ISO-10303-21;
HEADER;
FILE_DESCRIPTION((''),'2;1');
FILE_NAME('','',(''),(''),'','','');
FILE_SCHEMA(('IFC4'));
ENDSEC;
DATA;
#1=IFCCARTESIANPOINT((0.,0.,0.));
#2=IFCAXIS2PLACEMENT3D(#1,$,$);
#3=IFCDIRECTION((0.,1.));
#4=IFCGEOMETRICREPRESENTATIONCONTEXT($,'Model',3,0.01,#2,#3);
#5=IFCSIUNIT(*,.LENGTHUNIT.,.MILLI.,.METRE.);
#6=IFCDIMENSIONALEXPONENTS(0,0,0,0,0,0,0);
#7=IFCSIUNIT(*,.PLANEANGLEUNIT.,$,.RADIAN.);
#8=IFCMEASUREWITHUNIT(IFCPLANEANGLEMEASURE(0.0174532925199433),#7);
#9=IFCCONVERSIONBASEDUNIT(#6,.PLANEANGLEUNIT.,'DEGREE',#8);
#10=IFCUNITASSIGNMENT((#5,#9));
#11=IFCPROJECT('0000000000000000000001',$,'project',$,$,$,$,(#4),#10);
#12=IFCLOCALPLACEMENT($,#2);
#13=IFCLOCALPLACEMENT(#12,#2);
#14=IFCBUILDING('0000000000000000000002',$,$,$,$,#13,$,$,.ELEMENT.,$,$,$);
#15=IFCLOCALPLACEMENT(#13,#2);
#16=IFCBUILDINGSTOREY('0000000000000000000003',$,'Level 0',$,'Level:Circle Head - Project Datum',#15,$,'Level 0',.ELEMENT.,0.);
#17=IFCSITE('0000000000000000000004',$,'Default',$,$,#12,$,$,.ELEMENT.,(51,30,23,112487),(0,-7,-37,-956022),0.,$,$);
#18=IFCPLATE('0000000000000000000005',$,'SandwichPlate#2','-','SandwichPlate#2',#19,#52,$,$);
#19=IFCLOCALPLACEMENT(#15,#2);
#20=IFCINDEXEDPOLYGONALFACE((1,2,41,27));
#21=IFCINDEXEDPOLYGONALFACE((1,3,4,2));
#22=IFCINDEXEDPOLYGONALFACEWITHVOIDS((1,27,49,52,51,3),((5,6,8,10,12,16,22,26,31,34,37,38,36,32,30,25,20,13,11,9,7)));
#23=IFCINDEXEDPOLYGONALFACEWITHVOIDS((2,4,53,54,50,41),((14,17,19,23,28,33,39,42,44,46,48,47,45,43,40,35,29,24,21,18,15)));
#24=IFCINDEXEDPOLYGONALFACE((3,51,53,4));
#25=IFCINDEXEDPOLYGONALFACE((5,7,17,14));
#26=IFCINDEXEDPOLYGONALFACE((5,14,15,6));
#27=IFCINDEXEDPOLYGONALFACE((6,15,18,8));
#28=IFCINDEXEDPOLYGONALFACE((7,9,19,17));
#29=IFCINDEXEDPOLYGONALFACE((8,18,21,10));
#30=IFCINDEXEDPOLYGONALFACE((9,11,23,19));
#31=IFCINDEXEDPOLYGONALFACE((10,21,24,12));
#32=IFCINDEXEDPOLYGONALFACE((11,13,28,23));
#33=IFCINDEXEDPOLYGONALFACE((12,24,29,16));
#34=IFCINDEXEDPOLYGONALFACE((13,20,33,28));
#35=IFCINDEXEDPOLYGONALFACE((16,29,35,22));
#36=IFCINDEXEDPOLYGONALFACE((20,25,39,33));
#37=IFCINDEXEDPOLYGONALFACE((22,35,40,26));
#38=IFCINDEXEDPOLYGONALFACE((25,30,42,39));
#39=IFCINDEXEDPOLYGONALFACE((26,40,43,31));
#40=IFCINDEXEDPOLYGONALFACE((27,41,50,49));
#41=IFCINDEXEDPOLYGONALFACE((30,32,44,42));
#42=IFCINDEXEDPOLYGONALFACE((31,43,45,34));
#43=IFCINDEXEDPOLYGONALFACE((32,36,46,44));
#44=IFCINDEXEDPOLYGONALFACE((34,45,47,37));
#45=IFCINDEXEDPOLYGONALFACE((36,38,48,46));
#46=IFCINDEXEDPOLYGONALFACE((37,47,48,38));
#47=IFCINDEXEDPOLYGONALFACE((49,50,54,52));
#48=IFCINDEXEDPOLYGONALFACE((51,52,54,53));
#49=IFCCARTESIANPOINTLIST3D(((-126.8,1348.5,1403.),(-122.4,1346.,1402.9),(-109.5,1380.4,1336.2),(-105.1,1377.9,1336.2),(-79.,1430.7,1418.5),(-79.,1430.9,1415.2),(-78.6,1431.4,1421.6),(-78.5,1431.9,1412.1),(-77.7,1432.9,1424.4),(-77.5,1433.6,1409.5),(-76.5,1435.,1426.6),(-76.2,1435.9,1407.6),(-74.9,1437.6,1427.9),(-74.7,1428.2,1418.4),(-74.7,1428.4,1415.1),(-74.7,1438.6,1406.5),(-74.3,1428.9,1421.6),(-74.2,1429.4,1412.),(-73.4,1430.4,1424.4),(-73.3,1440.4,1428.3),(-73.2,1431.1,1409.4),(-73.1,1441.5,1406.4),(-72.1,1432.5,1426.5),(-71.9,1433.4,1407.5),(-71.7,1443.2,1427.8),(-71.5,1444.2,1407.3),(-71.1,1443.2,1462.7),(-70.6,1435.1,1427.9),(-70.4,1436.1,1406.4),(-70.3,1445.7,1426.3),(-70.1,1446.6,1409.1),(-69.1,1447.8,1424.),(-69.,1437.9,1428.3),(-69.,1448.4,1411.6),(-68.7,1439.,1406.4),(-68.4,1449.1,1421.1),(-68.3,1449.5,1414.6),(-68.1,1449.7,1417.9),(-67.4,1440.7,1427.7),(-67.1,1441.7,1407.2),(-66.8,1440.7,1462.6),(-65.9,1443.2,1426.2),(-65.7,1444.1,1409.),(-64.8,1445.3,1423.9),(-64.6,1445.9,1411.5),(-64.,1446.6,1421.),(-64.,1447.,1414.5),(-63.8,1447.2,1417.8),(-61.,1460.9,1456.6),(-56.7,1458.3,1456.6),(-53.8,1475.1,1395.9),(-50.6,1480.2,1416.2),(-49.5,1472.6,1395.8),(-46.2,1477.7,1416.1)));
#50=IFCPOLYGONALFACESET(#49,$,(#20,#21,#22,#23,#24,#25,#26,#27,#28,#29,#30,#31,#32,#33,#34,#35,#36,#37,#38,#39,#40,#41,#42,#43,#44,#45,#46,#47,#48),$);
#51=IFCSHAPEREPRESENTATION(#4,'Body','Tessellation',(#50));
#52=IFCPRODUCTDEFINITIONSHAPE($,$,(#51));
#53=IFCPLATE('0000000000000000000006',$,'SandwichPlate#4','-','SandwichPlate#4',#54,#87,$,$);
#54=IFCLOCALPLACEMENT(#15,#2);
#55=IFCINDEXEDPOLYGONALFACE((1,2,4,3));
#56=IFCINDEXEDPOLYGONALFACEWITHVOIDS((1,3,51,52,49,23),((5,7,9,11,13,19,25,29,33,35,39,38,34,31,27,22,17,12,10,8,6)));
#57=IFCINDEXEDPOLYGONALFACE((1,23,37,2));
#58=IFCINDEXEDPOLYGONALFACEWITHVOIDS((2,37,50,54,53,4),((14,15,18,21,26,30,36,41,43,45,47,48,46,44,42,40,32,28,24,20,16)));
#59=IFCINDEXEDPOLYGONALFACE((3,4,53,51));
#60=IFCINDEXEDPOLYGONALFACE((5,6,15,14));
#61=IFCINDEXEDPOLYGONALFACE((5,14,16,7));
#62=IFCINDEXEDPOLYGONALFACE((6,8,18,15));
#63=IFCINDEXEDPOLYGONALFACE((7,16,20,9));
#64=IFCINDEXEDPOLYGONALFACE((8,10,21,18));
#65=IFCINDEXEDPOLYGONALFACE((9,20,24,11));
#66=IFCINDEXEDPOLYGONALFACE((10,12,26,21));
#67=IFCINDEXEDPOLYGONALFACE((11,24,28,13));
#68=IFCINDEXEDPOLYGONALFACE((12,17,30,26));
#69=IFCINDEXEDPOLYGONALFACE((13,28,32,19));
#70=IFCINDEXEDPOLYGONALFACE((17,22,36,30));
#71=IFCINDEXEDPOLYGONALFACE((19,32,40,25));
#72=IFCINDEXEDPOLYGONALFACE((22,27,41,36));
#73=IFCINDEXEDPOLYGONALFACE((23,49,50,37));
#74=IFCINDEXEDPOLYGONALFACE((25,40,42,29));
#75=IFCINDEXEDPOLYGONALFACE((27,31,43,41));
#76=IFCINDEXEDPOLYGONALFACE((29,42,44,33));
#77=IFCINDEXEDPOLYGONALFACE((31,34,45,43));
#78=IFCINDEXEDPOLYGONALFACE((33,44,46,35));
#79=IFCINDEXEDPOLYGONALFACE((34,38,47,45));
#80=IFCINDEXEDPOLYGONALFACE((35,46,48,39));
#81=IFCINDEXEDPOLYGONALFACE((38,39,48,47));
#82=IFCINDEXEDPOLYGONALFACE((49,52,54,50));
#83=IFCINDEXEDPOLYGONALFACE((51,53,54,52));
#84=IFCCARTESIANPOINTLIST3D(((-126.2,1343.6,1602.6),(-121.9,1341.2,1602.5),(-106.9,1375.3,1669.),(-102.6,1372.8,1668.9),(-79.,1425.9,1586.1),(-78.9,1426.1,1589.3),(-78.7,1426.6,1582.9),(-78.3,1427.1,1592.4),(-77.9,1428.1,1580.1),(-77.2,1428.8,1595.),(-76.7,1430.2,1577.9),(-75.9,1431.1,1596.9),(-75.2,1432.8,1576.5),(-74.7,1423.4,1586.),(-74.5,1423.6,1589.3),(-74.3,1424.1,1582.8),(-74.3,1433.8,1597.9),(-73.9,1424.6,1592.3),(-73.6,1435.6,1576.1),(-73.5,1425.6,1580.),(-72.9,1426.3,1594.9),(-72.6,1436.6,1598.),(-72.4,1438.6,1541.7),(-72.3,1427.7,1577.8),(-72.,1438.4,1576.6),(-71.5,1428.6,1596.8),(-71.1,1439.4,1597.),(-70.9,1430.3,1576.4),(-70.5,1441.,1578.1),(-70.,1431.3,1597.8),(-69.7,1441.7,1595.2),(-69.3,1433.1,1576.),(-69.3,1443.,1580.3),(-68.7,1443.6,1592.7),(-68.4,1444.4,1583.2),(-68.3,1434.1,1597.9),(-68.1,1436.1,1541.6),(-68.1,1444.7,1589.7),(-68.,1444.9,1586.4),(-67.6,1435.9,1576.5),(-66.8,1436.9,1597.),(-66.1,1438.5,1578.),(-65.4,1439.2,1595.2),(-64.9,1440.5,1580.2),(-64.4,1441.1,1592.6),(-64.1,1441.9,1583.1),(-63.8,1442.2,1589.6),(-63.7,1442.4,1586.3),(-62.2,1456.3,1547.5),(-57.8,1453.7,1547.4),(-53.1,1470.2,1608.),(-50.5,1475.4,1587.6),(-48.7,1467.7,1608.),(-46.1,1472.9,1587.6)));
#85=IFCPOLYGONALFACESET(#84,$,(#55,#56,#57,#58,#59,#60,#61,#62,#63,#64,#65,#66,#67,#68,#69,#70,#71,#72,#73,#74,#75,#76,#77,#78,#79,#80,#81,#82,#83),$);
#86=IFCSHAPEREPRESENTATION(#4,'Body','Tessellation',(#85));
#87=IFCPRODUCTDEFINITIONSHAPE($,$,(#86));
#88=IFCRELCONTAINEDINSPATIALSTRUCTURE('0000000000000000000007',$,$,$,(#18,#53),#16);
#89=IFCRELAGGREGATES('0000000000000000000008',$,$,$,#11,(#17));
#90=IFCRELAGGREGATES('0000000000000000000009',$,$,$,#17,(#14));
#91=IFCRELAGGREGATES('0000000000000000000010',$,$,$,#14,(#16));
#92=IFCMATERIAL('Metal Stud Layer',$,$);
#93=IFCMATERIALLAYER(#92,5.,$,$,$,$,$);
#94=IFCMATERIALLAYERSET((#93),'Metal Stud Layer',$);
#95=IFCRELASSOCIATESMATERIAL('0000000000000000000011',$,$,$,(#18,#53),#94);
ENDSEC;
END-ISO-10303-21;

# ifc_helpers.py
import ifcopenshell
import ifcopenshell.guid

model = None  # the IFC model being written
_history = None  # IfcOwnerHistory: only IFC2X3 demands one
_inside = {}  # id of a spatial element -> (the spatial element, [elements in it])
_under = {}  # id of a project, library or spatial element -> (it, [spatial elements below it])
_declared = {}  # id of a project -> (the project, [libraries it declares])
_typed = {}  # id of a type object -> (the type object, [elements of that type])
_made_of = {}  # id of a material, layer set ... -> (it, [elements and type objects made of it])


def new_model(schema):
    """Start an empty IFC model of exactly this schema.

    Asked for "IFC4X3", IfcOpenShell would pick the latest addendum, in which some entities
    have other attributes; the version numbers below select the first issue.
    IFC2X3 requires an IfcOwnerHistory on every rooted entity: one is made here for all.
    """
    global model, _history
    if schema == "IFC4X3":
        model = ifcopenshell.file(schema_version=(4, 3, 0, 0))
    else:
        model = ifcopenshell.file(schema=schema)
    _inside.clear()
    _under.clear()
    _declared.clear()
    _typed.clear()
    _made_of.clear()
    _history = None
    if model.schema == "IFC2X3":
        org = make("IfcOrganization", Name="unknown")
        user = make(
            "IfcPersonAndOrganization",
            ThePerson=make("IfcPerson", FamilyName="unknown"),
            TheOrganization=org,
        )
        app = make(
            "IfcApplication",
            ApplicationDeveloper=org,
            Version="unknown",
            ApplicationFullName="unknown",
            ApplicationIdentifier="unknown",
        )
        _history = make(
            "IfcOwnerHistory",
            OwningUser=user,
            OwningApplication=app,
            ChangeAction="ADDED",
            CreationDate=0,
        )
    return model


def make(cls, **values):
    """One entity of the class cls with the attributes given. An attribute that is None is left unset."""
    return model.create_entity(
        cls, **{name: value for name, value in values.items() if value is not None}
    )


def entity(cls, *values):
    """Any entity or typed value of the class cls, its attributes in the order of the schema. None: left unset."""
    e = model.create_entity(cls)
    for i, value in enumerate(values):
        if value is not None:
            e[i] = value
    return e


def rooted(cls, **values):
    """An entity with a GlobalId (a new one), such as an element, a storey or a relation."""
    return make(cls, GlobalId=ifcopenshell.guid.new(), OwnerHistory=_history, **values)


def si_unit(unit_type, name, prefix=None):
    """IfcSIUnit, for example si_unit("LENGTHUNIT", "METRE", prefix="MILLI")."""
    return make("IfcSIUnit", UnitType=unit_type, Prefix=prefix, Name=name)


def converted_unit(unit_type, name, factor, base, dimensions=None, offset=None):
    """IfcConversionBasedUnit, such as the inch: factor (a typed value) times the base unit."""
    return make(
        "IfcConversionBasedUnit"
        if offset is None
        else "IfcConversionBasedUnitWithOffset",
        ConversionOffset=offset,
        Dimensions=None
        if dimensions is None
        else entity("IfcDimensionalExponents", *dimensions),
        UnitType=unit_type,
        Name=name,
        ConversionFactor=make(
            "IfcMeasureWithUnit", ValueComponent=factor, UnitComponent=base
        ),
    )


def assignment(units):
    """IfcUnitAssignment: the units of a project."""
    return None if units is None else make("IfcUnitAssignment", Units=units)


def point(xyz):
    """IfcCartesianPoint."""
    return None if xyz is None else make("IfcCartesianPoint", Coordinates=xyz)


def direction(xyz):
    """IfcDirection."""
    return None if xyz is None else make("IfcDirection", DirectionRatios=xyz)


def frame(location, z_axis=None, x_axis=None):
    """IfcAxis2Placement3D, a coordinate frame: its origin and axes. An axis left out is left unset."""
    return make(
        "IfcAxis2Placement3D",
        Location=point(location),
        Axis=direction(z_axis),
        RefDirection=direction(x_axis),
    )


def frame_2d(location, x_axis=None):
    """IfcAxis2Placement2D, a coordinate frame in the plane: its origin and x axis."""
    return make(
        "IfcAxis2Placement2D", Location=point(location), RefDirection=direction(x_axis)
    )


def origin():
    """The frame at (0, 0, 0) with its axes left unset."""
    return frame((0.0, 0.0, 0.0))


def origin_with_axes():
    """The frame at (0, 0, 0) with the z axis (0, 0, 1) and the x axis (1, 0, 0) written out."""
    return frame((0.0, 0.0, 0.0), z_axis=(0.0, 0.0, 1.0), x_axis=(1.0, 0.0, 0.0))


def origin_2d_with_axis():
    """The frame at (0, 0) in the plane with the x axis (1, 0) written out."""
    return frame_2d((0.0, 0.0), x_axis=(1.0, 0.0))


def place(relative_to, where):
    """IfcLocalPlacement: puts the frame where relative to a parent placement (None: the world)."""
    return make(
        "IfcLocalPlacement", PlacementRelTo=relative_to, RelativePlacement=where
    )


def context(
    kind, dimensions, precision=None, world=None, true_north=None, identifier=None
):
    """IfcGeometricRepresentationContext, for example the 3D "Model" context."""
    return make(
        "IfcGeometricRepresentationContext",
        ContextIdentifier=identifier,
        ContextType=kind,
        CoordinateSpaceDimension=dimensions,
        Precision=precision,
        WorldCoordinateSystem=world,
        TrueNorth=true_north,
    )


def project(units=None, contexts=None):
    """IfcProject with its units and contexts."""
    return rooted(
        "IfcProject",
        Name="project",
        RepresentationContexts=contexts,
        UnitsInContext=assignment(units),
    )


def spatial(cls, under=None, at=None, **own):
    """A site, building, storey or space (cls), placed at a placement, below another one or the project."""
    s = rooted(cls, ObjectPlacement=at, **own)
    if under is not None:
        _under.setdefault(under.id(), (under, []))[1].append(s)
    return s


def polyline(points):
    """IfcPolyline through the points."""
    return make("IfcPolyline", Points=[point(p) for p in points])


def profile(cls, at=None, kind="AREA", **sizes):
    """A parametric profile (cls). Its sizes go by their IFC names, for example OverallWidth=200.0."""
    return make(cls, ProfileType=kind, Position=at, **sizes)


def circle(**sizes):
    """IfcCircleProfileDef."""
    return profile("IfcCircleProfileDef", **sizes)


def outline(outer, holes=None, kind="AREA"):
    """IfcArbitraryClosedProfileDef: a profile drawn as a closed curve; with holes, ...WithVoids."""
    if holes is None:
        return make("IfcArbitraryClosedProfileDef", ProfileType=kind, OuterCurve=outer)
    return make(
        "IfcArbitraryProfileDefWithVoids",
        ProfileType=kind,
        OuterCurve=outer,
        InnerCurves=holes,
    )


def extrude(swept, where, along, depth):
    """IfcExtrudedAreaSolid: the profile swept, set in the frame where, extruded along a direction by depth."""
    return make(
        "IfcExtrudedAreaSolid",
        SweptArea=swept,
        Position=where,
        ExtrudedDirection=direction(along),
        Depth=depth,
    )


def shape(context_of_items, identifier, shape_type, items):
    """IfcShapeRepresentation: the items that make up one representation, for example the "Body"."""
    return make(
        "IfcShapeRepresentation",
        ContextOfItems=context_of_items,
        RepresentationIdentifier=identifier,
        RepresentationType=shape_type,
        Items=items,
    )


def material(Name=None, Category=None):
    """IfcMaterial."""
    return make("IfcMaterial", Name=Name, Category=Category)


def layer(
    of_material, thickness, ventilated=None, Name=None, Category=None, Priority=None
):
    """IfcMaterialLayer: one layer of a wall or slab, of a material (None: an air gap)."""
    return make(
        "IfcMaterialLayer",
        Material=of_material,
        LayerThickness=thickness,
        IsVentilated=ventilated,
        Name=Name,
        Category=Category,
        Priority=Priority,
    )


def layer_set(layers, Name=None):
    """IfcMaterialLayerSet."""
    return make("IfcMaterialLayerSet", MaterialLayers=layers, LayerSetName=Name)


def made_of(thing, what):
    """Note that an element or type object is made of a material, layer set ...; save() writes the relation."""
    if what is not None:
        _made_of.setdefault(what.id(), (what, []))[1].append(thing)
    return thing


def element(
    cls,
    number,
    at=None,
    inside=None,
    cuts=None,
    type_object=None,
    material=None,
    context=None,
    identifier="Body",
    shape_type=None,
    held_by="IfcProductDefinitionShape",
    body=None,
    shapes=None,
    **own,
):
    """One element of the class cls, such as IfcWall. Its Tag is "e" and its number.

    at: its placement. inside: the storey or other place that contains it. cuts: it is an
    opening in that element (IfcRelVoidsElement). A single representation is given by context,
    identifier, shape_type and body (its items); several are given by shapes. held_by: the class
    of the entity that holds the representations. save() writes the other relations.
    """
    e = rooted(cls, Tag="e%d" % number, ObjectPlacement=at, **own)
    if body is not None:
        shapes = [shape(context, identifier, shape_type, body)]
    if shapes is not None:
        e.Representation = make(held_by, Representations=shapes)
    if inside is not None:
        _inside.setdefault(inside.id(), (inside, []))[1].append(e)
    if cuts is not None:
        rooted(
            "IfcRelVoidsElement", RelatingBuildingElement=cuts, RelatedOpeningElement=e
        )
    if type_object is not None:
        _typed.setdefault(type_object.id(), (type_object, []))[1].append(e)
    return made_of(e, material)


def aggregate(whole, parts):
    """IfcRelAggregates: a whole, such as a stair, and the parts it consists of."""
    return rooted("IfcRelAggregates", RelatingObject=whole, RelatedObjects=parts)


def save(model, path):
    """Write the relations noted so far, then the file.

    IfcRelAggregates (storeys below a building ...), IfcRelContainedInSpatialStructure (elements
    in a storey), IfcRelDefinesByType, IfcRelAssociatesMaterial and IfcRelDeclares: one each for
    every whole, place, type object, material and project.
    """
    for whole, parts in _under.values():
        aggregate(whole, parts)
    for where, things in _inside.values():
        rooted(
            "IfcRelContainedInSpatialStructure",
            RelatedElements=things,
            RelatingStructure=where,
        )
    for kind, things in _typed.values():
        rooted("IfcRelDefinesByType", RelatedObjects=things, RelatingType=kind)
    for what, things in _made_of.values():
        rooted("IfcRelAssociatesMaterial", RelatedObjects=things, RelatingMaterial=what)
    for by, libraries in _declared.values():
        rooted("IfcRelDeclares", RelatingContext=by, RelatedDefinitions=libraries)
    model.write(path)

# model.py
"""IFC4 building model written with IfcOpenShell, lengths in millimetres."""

from ifc_helpers import new_model, entity, si_unit, converted_unit, direction, frame, origin, origin_with_axes, origin_2d_with_axis, place, context, project, spatial, polyline, circle, outline, extrude, material, layer, layer_set, element, save


model = new_model("IFC4")

# Units and contexts
model_context = context("Model", 3, precision=0.01, world=origin(), true_north=direction((0.0, 1.0)))
ifc_project = project(units=[si_unit("LENGTHUNIT", "METRE", prefix="MILLI"), converted_unit("PLANEANGLEUNIT", "DEGREE", entity("IfcPlaneAngleMeasure", 0.0174532925199433), si_unit("PLANEANGLEUNIT", "RADIAN"), dimensions=[0, 0, 0, 0, 0, 0, 0])], contexts=[model_context])

# Site, building, storey
site_placement = place(None, origin())
site = spatial("IfcSite", under=ifc_project, at=site_placement, Name="Default", CompositionType="ELEMENT", RefLatitude=(51, 30, 23, 112487), RefLongitude=(0, -7, -37, -956022), RefElevation=0.0)
building_placement = place(site_placement, origin())
building = spatial("IfcBuilding", under=site, at=building_placement, CompositionType="ELEMENT")
storey_placement = place(building_placement, origin())
storey = spatial("IfcBuildingStorey", under=building, at=storey_placement, Name="Level 0", ObjectType="Level:Circle Head - Project Datum", LongName="Level 0", CompositionType="ELEMENT", Elevation=0.0)

# Shared definitions
ifc_material_1 = material(Name="Metal Stud Layer")

# Shared definitions
ifc_layer_1 = layer(ifc_material_1, 5.0)
ifc_layer_set_1 = layer_set([ifc_layer_1], Name="Metal Stud Layer")

# Plates, openings
plate_1_placement = place(storey_placement, frame((-47.1, 1486.5, 1403.0), z_axis=(0.865935, -0.499948, -0.014432), x_axis=(-0.22762, -0.419615, 0.878699)))
plate_1 = element("IfcPlate", 1, at=plate_1_placement, inside=storey, material=ifc_layer_set_1, Name="SandwichPlate#2", Description="-", ObjectType="SandwichPlate#2", context=model_context, shape_type="SweptSolid", body=[
    extrude(outline(polyline([(0.0, 0.0), (76.0, 0.0), (76.0, 140.0), (0.0, 140.0), (0.0, 0.0)])), origin_with_axes(), (0.0, 0.0, 1.0), 5.0),
])
opening_1_placement = place(plate_1_placement, frame((0.0, 0.0, 0.0), z_axis=(0.0, 0.0, 1.0), x_axis=(1.0, 0.0, 0.0)))
element("IfcOpeningElement", 2, at=opening_1_placement, cuts=plate_1, ObjectType="Opening", context=model_context, shape_type="SweptSolid", body=[
    extrude(outline(polyline([(0.0, 0.0), (15.0, 0.0), (0.0, 15.0), (0.0, 0.0)])), origin(), (0.0, 0.0, 1.0), 5.0),
])
opening_2_placement = place(plate_1_placement, frame((0.0, 0.0, 0.0), z_axis=(0.0, 0.0, 1.0), x_axis=(1.0, 0.0, 0.0)))
element("IfcOpeningElement", 3, at=opening_2_placement, cuts=plate_1, ObjectType="Opening", context=model_context, shape_type="SweptSolid", body=[
    extrude(outline(polyline([(76.0, 0.0), (76.0, 15.0), (61.0, 0.0), (76.0, 0.0)])), origin(), (0.0, 0.0, 1.0), 5.0),
])
opening_3_placement = place(plate_1_placement, frame((38.0, 40.0, -0.5), z_axis=(0.0, 0.0, 1.0), x_axis=(0.0, 1.0, 0.0)))
element("IfcOpeningElement", 4, at=opening_3_placement, cuts=plate_1, ObjectType="Opening", context=model_context, shape_type="SweptSolid", body=[
    extrude(circle(Radius=11.0, at=origin_2d_with_axis()), origin(), (0.0, 0.0, 1.0), 6.0),
])
plate_2_placement = place(storey_placement, frame((-66.0, 1450.0, 1534.4), z_axis=(0.865935, -0.499948, -0.014432), x_axis=(0.254617, 0.415806, 0.873084)))
plate_2 = element("IfcPlate", 5, at=plate_2_placement, inside=storey, material=ifc_layer_set_1, Name="SandwichPlate#4", Description="-", ObjectType="SandwichPlate#4", context=model_context, shape_type="SweptSolid", body=[
    extrude(outline(polyline([(0.0, 0.0), (76.0, 0.0), (76.0, 140.0), (0.0, 140.0), (0.0, 0.0)])), origin_with_axes(), (0.0, 0.0, 1.0), 5.0),
])
opening_4_placement = place(plate_2_placement, frame((0.0, 0.0, 0.0), z_axis=(0.0, 0.0, 1.0), x_axis=(1.0, 0.0, 0.0)))
element("IfcOpeningElement", 6, at=opening_4_placement, cuts=plate_2, ObjectType="Opening", context=model_context, shape_type="SweptSolid", body=[
    extrude(outline(polyline([(0.0, 0.0), (15.0, 0.0), (0.0, 15.0), (0.0, 0.0)])), origin(), (0.0, 0.0, 1.0), 5.0),
])
opening_5_placement = place(plate_2_placement, frame((0.0, 0.0, 0.0), z_axis=(0.0, 0.0, 1.0), x_axis=(1.0, 0.0, 0.0)))
element("IfcOpeningElement", 7, at=opening_5_placement, cuts=plate_2, ObjectType="Opening", context=model_context, shape_type="SweptSolid", body=[
    extrude(outline(polyline([(76.0, 0.0), (76.0, 15.0), (61.0, 0.0), (76.0, 0.0)])), origin(), (0.0, 0.0, 1.0), 5.0),
])
opening_6_placement = place(plate_2_placement, frame((38.0, 40.0, -0.5), z_axis=(0.0, 0.0, 1.0), x_axis=(0.0, 1.0, 0.0)))
element("IfcOpeningElement", 8, at=opening_6_placement, cuts=plate_2, ObjectType="Opening", context=model_context, shape_type="SweptSolid", body=[
    extrude(circle(Radius=11.0, at=origin_2d_with_axis()), origin(), (0.0, 0.0, 1.0), 6.0),
])

save(model, "model.ifc")
